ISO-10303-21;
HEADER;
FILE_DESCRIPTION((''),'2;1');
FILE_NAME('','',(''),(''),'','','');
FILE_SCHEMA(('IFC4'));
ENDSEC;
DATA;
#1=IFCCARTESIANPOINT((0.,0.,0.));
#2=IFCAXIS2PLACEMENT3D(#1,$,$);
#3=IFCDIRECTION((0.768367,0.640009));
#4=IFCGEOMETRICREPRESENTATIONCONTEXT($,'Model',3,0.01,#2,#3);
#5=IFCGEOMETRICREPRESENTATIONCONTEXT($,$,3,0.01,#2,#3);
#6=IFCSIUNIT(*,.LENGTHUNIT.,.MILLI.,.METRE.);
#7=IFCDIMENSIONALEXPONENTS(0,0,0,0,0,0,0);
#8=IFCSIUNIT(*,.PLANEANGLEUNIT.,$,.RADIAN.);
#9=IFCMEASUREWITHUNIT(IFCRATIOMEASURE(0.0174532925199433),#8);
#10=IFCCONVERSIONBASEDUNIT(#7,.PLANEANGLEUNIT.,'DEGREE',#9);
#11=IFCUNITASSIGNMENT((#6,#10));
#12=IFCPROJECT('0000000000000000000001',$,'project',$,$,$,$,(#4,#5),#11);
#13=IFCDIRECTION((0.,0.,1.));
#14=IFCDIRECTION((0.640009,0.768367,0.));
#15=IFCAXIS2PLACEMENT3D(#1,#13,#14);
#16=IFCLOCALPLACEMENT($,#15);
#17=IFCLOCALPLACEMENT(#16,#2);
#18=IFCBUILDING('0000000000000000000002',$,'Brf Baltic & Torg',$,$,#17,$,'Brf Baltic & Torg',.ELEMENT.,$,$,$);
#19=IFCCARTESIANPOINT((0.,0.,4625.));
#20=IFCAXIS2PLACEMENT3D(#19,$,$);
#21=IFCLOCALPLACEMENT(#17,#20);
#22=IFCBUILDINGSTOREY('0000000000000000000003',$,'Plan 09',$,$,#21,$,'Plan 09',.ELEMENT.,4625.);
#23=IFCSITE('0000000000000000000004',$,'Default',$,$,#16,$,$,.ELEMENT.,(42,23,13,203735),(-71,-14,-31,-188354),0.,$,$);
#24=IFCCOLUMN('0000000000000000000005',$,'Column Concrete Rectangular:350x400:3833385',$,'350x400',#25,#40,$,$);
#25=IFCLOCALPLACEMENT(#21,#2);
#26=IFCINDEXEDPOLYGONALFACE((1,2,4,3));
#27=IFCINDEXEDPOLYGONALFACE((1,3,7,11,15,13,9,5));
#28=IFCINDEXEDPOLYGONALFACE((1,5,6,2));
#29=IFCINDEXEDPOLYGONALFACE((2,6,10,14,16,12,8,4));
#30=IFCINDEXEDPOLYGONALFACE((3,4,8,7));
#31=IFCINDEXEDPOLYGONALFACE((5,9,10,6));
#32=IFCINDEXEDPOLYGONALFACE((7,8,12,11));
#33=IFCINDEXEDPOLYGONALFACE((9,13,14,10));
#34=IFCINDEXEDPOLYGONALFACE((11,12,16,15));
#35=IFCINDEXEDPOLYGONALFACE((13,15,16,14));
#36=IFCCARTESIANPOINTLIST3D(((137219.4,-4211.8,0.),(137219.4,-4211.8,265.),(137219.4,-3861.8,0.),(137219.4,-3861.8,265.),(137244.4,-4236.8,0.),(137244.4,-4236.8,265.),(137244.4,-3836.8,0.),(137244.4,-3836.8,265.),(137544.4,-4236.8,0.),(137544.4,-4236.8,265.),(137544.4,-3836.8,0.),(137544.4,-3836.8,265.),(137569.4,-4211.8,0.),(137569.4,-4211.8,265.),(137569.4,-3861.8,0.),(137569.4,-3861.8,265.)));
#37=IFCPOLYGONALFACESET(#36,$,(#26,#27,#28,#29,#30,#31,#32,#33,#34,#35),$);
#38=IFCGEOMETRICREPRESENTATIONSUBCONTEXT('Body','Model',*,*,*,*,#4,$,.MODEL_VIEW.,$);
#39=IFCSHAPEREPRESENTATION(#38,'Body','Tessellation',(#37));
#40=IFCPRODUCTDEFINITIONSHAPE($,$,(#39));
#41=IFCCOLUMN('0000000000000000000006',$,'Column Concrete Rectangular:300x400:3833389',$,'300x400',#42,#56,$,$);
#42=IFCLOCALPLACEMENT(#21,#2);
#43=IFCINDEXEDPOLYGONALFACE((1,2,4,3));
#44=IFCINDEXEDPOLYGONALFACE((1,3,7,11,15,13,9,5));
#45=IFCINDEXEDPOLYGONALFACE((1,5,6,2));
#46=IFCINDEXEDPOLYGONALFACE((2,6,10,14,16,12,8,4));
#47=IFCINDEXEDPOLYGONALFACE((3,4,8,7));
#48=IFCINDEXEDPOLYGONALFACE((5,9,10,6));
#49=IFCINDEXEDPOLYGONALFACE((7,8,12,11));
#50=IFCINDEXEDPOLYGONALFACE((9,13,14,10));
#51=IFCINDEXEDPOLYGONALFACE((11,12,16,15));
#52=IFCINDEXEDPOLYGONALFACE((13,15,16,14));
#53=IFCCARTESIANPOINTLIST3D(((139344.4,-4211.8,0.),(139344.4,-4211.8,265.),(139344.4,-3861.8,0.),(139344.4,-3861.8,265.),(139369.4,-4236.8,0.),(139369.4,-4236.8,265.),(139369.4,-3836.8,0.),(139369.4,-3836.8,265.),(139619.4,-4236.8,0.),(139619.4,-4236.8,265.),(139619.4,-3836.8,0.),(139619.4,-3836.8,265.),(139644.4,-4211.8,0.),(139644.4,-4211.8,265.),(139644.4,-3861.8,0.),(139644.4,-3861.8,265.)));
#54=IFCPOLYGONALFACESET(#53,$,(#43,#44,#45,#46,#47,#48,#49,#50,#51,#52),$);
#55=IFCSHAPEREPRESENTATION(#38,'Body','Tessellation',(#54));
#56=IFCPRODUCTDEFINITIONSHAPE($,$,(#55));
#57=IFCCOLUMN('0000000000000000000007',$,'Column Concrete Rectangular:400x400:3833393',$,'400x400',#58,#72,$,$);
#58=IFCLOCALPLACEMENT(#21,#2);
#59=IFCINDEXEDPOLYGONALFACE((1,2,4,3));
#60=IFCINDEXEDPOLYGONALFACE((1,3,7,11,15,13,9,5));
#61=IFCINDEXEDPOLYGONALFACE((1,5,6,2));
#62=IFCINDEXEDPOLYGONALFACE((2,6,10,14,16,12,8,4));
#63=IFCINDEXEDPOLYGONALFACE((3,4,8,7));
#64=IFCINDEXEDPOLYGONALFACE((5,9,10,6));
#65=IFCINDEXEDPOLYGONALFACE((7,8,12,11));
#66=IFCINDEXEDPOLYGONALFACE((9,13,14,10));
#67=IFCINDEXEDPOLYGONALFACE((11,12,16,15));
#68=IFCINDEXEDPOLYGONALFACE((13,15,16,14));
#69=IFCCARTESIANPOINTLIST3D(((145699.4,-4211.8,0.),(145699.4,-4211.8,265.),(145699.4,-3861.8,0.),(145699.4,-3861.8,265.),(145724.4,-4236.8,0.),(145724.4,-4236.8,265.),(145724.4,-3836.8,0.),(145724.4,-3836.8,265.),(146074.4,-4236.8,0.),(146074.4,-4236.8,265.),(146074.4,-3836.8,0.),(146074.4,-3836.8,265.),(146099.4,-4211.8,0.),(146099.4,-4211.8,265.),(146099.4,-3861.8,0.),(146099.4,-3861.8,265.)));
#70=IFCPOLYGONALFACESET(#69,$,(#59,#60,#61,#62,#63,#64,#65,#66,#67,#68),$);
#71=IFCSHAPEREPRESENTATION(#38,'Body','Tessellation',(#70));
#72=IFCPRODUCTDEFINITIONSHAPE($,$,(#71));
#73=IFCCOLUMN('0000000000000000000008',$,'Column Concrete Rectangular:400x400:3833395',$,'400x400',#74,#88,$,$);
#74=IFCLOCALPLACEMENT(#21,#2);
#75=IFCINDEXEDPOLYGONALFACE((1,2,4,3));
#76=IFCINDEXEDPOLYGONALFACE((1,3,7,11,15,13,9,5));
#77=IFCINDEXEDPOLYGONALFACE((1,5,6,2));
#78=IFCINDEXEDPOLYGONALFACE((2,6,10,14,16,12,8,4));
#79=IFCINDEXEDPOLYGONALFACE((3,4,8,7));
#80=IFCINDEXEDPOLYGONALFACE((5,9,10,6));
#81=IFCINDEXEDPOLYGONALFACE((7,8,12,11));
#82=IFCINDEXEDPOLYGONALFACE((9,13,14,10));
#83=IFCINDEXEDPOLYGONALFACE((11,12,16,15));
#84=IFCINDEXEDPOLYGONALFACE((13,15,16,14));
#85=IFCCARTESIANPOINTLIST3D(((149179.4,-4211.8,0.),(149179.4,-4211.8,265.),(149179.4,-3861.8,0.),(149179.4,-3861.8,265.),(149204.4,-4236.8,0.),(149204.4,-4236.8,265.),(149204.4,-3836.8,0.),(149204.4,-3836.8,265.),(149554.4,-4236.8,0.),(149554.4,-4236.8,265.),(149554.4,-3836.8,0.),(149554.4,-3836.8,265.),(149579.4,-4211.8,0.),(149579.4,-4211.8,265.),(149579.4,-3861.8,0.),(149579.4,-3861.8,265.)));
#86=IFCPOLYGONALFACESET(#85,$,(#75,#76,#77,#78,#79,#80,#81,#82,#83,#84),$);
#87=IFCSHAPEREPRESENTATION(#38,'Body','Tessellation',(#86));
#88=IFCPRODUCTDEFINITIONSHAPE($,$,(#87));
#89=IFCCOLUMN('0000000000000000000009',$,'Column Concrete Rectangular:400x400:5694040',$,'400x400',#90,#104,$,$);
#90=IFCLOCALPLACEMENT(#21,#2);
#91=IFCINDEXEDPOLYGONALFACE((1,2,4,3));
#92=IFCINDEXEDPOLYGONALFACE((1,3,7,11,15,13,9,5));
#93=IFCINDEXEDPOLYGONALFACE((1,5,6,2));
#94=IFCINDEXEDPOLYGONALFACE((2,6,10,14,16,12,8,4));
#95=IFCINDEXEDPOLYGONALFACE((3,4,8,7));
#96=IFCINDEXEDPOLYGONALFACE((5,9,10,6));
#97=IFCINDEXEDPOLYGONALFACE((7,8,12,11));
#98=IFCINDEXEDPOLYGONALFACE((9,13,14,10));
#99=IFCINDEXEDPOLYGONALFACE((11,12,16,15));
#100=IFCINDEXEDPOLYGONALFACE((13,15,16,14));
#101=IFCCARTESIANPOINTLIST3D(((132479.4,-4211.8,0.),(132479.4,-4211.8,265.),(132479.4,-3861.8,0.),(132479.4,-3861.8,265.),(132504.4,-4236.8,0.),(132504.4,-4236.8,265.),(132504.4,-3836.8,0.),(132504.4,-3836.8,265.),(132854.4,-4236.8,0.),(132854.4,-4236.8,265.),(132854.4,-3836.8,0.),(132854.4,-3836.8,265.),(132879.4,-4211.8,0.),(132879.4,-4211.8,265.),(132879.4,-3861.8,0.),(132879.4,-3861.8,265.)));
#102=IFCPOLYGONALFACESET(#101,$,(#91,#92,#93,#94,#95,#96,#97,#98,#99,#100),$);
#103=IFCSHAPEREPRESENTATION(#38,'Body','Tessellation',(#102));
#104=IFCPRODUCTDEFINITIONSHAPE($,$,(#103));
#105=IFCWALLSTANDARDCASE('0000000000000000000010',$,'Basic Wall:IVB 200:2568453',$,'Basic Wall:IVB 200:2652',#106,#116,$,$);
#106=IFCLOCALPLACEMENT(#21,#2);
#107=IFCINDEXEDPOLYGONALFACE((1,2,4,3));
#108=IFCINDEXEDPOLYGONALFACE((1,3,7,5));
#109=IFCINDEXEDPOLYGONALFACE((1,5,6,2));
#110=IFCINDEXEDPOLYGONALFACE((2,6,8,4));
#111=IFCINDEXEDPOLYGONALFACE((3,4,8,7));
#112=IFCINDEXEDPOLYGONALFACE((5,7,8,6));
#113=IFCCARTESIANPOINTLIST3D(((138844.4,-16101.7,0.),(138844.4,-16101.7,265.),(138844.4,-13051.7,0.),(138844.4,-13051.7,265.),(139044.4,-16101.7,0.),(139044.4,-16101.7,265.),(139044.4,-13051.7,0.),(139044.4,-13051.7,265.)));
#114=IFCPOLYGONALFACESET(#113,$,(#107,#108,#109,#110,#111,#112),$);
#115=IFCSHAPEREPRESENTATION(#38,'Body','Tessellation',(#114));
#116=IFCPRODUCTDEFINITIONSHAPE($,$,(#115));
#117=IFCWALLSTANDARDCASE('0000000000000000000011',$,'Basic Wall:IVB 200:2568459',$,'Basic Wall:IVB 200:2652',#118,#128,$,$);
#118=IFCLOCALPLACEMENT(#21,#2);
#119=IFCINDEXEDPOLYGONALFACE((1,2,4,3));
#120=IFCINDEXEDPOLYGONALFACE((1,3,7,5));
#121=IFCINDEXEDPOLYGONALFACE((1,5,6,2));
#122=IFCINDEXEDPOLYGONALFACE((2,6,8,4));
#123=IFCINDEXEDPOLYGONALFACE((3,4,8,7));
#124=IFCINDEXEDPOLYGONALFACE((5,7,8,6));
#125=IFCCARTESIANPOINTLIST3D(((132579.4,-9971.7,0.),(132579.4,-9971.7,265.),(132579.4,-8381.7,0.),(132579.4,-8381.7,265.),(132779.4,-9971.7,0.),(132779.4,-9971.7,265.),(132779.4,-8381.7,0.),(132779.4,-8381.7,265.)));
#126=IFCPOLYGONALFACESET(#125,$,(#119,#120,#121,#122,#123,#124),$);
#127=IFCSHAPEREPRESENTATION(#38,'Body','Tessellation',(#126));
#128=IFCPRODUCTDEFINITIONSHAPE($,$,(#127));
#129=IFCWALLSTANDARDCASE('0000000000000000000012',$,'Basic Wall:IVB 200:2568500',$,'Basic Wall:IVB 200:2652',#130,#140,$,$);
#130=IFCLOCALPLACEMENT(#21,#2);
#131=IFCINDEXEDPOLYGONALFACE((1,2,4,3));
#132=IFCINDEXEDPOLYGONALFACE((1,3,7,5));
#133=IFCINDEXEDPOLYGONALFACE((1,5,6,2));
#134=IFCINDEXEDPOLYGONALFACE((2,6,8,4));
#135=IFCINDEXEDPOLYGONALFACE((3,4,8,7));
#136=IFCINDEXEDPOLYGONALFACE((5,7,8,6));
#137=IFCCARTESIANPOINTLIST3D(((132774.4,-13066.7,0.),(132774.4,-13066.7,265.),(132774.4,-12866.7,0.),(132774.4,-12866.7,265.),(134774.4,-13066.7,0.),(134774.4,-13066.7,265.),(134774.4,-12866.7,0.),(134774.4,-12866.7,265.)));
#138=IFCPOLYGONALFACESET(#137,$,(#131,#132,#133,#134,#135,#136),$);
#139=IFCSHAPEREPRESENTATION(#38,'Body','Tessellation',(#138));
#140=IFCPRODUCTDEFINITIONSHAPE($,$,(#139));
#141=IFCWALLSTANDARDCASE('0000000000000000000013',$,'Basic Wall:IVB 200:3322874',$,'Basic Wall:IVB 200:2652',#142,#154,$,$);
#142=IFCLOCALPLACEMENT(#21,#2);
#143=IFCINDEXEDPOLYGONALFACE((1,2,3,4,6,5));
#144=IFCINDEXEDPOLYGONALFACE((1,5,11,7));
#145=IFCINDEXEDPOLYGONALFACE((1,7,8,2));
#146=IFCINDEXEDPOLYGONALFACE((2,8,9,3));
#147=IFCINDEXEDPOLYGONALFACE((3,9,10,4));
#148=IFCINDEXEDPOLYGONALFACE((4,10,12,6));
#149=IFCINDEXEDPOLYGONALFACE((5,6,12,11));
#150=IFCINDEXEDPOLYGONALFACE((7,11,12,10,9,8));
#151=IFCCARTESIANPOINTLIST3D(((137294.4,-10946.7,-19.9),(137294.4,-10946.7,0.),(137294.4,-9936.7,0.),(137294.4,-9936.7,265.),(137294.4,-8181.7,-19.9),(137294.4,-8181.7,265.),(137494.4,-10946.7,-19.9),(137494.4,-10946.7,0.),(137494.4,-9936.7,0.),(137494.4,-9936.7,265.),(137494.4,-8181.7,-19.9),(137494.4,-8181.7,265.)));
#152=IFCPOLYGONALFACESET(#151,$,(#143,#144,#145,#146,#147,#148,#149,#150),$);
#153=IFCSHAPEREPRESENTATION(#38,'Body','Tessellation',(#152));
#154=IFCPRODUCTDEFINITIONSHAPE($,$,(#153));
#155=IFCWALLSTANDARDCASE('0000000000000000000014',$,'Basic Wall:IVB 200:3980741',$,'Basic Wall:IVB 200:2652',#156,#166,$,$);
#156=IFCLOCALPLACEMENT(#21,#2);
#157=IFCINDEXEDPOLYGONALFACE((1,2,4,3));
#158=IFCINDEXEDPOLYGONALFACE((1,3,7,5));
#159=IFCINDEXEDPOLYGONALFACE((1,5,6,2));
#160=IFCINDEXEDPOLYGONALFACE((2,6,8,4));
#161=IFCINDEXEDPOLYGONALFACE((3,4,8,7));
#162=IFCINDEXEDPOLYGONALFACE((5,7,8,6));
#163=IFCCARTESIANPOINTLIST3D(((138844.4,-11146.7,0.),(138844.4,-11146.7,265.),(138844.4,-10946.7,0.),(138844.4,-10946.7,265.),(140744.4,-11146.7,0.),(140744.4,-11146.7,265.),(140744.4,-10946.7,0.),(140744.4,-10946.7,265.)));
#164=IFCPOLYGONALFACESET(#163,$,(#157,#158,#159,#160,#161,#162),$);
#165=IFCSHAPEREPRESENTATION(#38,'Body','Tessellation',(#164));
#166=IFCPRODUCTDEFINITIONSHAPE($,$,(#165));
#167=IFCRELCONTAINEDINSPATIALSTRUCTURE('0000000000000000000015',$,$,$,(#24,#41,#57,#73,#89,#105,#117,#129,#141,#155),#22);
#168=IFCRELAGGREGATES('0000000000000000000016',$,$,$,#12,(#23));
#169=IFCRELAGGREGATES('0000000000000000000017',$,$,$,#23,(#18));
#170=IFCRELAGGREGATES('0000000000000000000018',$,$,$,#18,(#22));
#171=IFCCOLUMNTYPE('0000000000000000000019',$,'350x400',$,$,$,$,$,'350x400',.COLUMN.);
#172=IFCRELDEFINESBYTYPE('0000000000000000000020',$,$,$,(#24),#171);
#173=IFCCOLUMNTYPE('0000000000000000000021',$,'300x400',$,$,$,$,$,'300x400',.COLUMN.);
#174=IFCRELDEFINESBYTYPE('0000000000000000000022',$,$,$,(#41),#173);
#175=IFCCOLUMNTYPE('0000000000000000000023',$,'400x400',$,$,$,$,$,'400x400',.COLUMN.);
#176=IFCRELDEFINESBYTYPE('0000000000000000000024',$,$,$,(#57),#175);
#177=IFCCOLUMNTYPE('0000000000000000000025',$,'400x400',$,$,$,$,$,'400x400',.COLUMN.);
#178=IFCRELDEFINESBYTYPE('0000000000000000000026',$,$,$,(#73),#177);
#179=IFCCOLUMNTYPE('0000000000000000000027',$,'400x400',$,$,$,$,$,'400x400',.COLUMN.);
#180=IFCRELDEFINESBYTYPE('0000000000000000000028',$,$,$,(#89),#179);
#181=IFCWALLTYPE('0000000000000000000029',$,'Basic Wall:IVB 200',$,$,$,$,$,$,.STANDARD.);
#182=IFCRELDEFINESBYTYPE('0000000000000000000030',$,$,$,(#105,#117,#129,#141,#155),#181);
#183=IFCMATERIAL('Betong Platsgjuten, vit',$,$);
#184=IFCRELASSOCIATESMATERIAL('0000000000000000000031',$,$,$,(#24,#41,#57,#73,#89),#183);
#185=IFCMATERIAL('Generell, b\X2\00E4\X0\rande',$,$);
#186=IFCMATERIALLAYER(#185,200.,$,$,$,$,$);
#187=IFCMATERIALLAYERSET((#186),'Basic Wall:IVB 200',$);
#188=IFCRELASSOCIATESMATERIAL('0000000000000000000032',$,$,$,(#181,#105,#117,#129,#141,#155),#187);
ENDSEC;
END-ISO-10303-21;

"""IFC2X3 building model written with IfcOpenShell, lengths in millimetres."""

from ifc_helpers import new_model, entity, si_unit, converted_unit, direction, frame, frame_2d, origin, place, context, subcontext, project, spatial, polyline, rectangle, outline, extrude, clip, halfspace, source, transform, mapped, material, layer, layer_set, layer_usage, type_object, type_shapes, element, save


model = new_model("IFC2X3")

# Units and contexts
model_context = context("Model", 3, precision=0.01, world=origin(), true_north=direction((0.768367, 0.640009)))
context_of_model = context(None, 3, precision=0.01, world=origin(), true_north=direction((0.768367, 0.640009)))
body_context = subcontext(model_context, "Body", "Model", "MODEL_VIEW")
ifc_project = project(units=[si_unit("LENGTHUNIT", "METRE", prefix="MILLI"), converted_unit("PLANEANGLEUNIT", "DEGREE", entity("IfcRatioMeasure", 0.0174532925199433), si_unit("PLANEANGLEUNIT", "RADIAN"), dimensions=[0, 0, 0, 0, 0, 0, 0])], contexts=[model_context, context_of_model])

# Site, building, storey
site_placement = place(None, frame((0.0, 0.0, 0.0), z_axis=(0.0, 0.0, 1.0), x_axis=(0.640009, 0.768367, 0.0)))
site = spatial("IfcSite", under=ifc_project, at=site_placement, Name="Default", CompositionType="ELEMENT", RefLatitude=(42, 23, 13, 203735), RefLongitude=(-71, -14, -31, -188354), RefElevation=0.0)
building_placement = place(site_placement, origin())
building = spatial("IfcBuilding", under=site, at=building_placement, Name="Brf Baltic & Torg", LongName="Brf Baltic & Torg", CompositionType="ELEMENT")
storey_placement = place(building_placement, frame((0.0, 0.0, 4625.0)))
storey = spatial("IfcBuildingStorey", under=building, at=storey_placement, Name="Plan 09", LongName="Plan 09", CompositionType="ELEMENT", Elevation=4625.0)

# Columns
ifc_material_1 = material(Name="Betong Platsgjuten, vit")
column_type_1 = type_object("IfcColumnType", Name="350x400", ElementType="350x400", PredefinedType="COLUMN")
shared_shape_1 = source(origin(), body_context, "Body", "SweptSolid", [
    extrude(outline(polyline([(-175.0, -175.0), (175.0, -175.0), (200.0, -150.0), (200.0, 150.0), (175.0, 175.0), (-175.0, 175.0), (-200.0, 150.0), (-200.0, -150.0), (-175.0, -175.0)])), frame((0.0, 0.0, 4625.0), z_axis=(0.0, 0.0, 1.0), x_axis=(0.0, -1.0, 0.0)), (0.0, 0.0, 1.0), 265.0),
])
type_shapes(column_type_1, [shared_shape_1])
column_1_placement = place(storey_placement, frame((137394.4, -4036.8, -4625.0)))
element("IfcColumn", 1, at=column_1_placement, inside=storey, type_object=column_type_1, material=ifc_material_1, Name="Column Concrete Rectangular:350x400:3833385", ObjectType="350x400", context=body_context, shape_type="MappedRepresentation", body=[
    mapped(shared_shape_1, transform((0.0, 0.0, 0.0), scale=1.0)),
])
column_type_2 = type_object("IfcColumnType", Name="300x400", ElementType="300x400", PredefinedType="COLUMN")
shared_shape_2 = source(origin(), body_context, "Body", "SweptSolid", [
    extrude(outline(polyline([(-175.0, -150.0), (175.0, -150.0), (200.0, -125.0), (200.0, 125.0), (175.0, 150.0), (-175.0, 150.0), (-200.0, 125.0), (-200.0, -125.0), (-175.0, -150.0)])), frame((0.0, 0.0, 4625.0), z_axis=(0.0, 0.0, 1.0), x_axis=(0.0, -1.0, 0.0)), (0.0, 0.0, 1.0), 265.0),
])
type_shapes(column_type_2, [shared_shape_2])
column_2_placement = place(storey_placement, frame((139494.4, -4036.8, -4625.0)))
element("IfcColumn", 2, at=column_2_placement, inside=storey, type_object=column_type_2, material=ifc_material_1, Name="Column Concrete Rectangular:300x400:3833389", ObjectType="300x400", context=body_context, shape_type="MappedRepresentation", body=[
    mapped(shared_shape_2, transform((0.0, 0.0, 0.0), scale=1.0)),
])
column_type_3 = type_object("IfcColumnType", Name="400x400", ElementType="400x400", PredefinedType="COLUMN")
shared_shape_3 = source(origin(), body_context, "Body", "SweptSolid", [
    extrude(outline(polyline([(-175.0, -200.0), (175.0, -200.0), (200.0, -175.0), (200.0, 175.0), (175.0, 200.0), (-175.0, 200.0), (-200.0, 175.0), (-200.0, -175.0), (-175.0, -200.0)])), frame((0.0, 0.0, 4625.0), z_axis=(0.0, 0.0, 1.0), x_axis=(0.0, -1.0, 0.0)), (0.0, 0.0, 1.0), 265.0),
])
type_shapes(column_type_3, [shared_shape_3])
column_3_placement = place(storey_placement, frame((145899.4, -4036.8, -4625.0)))
element("IfcColumn", 3, at=column_3_placement, inside=storey, type_object=column_type_3, material=ifc_material_1, Name="Column Concrete Rectangular:400x400:3833393", ObjectType="400x400", context=body_context, shape_type="MappedRepresentation", body=[
    mapped(shared_shape_3, transform((0.0, 0.0, 0.0), scale=1.0)),
])
column_type_4 = type_object("IfcColumnType", Name="400x400", ElementType="400x400", PredefinedType="COLUMN")
shared_shape_4 = source(origin(), body_context, "Body", "SweptSolid", [
    extrude(outline(polyline([(-175.0, -200.0), (175.0, -200.0), (200.0, -175.0), (200.0, 175.0), (175.0, 200.0), (-175.0, 200.0), (-200.0, 175.0), (-200.0, -175.0), (-175.0, -200.0)])), frame((0.0, 0.0, 4625.0), z_axis=(0.0, 0.0, 1.0), x_axis=(0.0, -1.0, 0.0)), (0.0, 0.0, 1.0), 265.0),
])
type_shapes(column_type_4, [shared_shape_4])
column_4_placement = place(storey_placement, frame((149379.4, -4036.8, -4625.0)))
element("IfcColumn", 4, at=column_4_placement, inside=storey, type_object=column_type_4, material=ifc_material_1, Name="Column Concrete Rectangular:400x400:3833395", ObjectType="400x400", context=body_context, shape_type="MappedRepresentation", body=[
    mapped(shared_shape_4, transform((0.0, 0.0, 0.0), scale=1.0)),
])
column_type_5 = type_object("IfcColumnType", Name="400x400", ElementType="400x400", PredefinedType="COLUMN")
shared_shape_5 = source(origin(), body_context, "Body", "SweptSolid", [
    extrude(outline(polyline([(-175.0, -200.0), (175.0, -200.0), (200.0, -175.0), (200.0, 175.0), (175.0, 200.0), (-175.0, 200.0), (-200.0, 175.0), (-200.0, -175.0), (-175.0, -200.0)])), frame((0.0, 0.0, 4625.0), z_axis=(0.0, 0.0, 1.0), x_axis=(0.0, -1.0, 0.0)), (0.0, 0.0, 1.0), 265.0),
])
type_shapes(column_type_5, [shared_shape_5])
column_5_placement = place(storey_placement, frame((132679.4, -4036.8, -4625.0)))
element("IfcColumn", 5, at=column_5_placement, inside=storey, type_object=column_type_5, material=ifc_material_1, Name="Column Concrete Rectangular:400x400:5694040", ObjectType="400x400", context=body_context, shape_type="MappedRepresentation", body=[
    mapped(shared_shape_5, transform((0.0, 0.0, 0.0), scale=1.0)),
])

# Shared definitions
ifc_material_2 = material(Name="Generell, bärande")
ifc_layer = layer(ifc_material_2, 200.0)
ifc_layer_set = layer_set([ifc_layer], Name="Basic Wall:IVB 200")
wall_type = type_object("IfcWallType", Name="Basic Wall:IVB 200", PredefinedType="STANDARD", material=ifc_layer_set)

# Walls
ifc_layer_usage_1 = layer_usage(ifc_layer_set, "AXIS2", "NEGATIVE", 100.0)
wall_1_placement = place(storey_placement, frame((138944.4, -13051.7, 0.0), z_axis=(0.0, 0.0, 1.0), x_axis=(0.0, -1.0, 0.0)))
element("IfcWallStandardCase", 6, at=wall_1_placement, inside=storey, type_object=wall_type, material=ifc_layer_usage_1, Name="Basic Wall:IVB 200:2568453", ObjectType="Basic Wall:IVB 200:2652", context=body_context, shape_type="Clipping", body=[
    clip(extrude(rectangle(XDim=3050.0, YDim=200.0, at=frame_2d((1525.0, 0.0), x_axis=(-1.0, 0.0))), origin(), (0.0, 0.0, 1.0), 265.0), halfspace(origin(), True)),
])
ifc_layer_usage_2 = layer_usage(ifc_layer_set, "AXIS2", "NEGATIVE", 100.0)
wall_2_placement = place(storey_placement, frame((132679.4, -9971.7, 0.0), z_axis=(0.0, 0.0, 1.0), x_axis=(0.0, 1.0, 0.0)))
element("IfcWallStandardCase", 7, at=wall_2_placement, inside=storey, type_object=wall_type, material=ifc_layer_usage_2, Name="Basic Wall:IVB 200:2568459", ObjectType="Basic Wall:IVB 200:2652", context=body_context, shape_type="Clipping", body=[
    clip(extrude(rectangle(XDim=1590.0, YDim=200.0, at=frame_2d((795.0, 0.0), x_axis=(-1.0, 0.0))), origin(), (0.0, 0.0, 1.0), 265.0), halfspace(origin(), True)),
])

# Wall
ifc_layer_usage_3 = layer_usage(ifc_layer_set, "AXIS2", "NEGATIVE", 100.0)
wall_3_placement = place(storey_placement, frame((134774.4, -12966.7, 0.0), z_axis=(0.0, 0.0, 1.0), x_axis=(-1.0, 0.0, 0.0)))
element("IfcWallStandardCase", 8, at=wall_3_placement, inside=storey, type_object=wall_type, material=ifc_layer_usage_3, Name="Basic Wall:IVB 200:2568500", ObjectType="Basic Wall:IVB 200:2652", context=body_context, shape_type="Clipping", body=[
    clip(extrude(rectangle(XDim=2000.0, YDim=200.0, at=frame_2d((1000.0, 0.0), x_axis=(-1.0, 0.0))), origin(), (0.0, 0.0, 1.0), 265.0), halfspace(origin(), True)),
])

# Wall, opening
ifc_layer_usage_4 = layer_usage(ifc_layer_set, "AXIS2", "NEGATIVE", 100.0)
wall_4_placement = place(storey_placement, frame((137394.4, -8181.7, -19.9), z_axis=(0.0, 0.0, 1.0), x_axis=(0.0, -1.0, 0.0)))
wall_4 = element("IfcWallStandardCase", 9, at=wall_4_placement, inside=storey, type_object=wall_type, material=ifc_layer_usage_4, Name="Basic Wall:IVB 200:3322874", ObjectType="Basic Wall:IVB 200:2652", context=body_context, shape_type="Clipping", body=[
    clip(extrude(rectangle(XDim=2765.0, YDim=200.0, at=frame_2d((1382.5, 0.0), x_axis=(-1.0, 0.0))), origin(), (0.0, 0.0, 1.0), 284.9), halfspace(frame((0.0, 0.0, -19.9)), True)),
])
opening_1_placement = place(wall_4_placement, frame((-8181.7, -137394.4, 19.9), z_axis=(0.0, 0.0, 1.0), x_axis=(0.0, 1.0, 0.0)))
element("IfcOpeningElement", 10, at=opening_1_placement, cuts=wall_4, ObjectType="Opening", context=body_context, shape_type="SweptSolid", body=[
    extrude(rectangle(XDim=2110.0, YDim=1010.0, at=frame_2d((0.0, 0.0), x_axis=(1.0, 0.0))), frame((135770.4, -10441.7, 1055.0), z_axis=(1.0, 0.0, 0.0), x_axis=(0.0, 0.0, 1.0)), (0.0, 0.0, 1.0), 3048.0),
])

# Wall
ifc_layer_usage_5 = layer_usage(ifc_layer_set, "AXIS2", "NEGATIVE", 100.0)
wall_5_placement = place(storey_placement, frame((138844.4, -11046.7, 0.0)))
element("IfcWallStandardCase", 11, at=wall_5_placement, inside=storey, type_object=wall_type, material=ifc_layer_usage_5, Name="Basic Wall:IVB 200:3980741", ObjectType="Basic Wall:IVB 200:2652", context=body_context, shape_type="Clipping", body=[
    clip(extrude(rectangle(XDim=1900.0, YDim=200.0, at=frame_2d((950.0, 0.0), x_axis=(-1.0, 0.0))), origin(), (0.0, 0.0, 1.0), 265.0), halfspace(origin(), True)),
])

save(model, "model.ifc")
